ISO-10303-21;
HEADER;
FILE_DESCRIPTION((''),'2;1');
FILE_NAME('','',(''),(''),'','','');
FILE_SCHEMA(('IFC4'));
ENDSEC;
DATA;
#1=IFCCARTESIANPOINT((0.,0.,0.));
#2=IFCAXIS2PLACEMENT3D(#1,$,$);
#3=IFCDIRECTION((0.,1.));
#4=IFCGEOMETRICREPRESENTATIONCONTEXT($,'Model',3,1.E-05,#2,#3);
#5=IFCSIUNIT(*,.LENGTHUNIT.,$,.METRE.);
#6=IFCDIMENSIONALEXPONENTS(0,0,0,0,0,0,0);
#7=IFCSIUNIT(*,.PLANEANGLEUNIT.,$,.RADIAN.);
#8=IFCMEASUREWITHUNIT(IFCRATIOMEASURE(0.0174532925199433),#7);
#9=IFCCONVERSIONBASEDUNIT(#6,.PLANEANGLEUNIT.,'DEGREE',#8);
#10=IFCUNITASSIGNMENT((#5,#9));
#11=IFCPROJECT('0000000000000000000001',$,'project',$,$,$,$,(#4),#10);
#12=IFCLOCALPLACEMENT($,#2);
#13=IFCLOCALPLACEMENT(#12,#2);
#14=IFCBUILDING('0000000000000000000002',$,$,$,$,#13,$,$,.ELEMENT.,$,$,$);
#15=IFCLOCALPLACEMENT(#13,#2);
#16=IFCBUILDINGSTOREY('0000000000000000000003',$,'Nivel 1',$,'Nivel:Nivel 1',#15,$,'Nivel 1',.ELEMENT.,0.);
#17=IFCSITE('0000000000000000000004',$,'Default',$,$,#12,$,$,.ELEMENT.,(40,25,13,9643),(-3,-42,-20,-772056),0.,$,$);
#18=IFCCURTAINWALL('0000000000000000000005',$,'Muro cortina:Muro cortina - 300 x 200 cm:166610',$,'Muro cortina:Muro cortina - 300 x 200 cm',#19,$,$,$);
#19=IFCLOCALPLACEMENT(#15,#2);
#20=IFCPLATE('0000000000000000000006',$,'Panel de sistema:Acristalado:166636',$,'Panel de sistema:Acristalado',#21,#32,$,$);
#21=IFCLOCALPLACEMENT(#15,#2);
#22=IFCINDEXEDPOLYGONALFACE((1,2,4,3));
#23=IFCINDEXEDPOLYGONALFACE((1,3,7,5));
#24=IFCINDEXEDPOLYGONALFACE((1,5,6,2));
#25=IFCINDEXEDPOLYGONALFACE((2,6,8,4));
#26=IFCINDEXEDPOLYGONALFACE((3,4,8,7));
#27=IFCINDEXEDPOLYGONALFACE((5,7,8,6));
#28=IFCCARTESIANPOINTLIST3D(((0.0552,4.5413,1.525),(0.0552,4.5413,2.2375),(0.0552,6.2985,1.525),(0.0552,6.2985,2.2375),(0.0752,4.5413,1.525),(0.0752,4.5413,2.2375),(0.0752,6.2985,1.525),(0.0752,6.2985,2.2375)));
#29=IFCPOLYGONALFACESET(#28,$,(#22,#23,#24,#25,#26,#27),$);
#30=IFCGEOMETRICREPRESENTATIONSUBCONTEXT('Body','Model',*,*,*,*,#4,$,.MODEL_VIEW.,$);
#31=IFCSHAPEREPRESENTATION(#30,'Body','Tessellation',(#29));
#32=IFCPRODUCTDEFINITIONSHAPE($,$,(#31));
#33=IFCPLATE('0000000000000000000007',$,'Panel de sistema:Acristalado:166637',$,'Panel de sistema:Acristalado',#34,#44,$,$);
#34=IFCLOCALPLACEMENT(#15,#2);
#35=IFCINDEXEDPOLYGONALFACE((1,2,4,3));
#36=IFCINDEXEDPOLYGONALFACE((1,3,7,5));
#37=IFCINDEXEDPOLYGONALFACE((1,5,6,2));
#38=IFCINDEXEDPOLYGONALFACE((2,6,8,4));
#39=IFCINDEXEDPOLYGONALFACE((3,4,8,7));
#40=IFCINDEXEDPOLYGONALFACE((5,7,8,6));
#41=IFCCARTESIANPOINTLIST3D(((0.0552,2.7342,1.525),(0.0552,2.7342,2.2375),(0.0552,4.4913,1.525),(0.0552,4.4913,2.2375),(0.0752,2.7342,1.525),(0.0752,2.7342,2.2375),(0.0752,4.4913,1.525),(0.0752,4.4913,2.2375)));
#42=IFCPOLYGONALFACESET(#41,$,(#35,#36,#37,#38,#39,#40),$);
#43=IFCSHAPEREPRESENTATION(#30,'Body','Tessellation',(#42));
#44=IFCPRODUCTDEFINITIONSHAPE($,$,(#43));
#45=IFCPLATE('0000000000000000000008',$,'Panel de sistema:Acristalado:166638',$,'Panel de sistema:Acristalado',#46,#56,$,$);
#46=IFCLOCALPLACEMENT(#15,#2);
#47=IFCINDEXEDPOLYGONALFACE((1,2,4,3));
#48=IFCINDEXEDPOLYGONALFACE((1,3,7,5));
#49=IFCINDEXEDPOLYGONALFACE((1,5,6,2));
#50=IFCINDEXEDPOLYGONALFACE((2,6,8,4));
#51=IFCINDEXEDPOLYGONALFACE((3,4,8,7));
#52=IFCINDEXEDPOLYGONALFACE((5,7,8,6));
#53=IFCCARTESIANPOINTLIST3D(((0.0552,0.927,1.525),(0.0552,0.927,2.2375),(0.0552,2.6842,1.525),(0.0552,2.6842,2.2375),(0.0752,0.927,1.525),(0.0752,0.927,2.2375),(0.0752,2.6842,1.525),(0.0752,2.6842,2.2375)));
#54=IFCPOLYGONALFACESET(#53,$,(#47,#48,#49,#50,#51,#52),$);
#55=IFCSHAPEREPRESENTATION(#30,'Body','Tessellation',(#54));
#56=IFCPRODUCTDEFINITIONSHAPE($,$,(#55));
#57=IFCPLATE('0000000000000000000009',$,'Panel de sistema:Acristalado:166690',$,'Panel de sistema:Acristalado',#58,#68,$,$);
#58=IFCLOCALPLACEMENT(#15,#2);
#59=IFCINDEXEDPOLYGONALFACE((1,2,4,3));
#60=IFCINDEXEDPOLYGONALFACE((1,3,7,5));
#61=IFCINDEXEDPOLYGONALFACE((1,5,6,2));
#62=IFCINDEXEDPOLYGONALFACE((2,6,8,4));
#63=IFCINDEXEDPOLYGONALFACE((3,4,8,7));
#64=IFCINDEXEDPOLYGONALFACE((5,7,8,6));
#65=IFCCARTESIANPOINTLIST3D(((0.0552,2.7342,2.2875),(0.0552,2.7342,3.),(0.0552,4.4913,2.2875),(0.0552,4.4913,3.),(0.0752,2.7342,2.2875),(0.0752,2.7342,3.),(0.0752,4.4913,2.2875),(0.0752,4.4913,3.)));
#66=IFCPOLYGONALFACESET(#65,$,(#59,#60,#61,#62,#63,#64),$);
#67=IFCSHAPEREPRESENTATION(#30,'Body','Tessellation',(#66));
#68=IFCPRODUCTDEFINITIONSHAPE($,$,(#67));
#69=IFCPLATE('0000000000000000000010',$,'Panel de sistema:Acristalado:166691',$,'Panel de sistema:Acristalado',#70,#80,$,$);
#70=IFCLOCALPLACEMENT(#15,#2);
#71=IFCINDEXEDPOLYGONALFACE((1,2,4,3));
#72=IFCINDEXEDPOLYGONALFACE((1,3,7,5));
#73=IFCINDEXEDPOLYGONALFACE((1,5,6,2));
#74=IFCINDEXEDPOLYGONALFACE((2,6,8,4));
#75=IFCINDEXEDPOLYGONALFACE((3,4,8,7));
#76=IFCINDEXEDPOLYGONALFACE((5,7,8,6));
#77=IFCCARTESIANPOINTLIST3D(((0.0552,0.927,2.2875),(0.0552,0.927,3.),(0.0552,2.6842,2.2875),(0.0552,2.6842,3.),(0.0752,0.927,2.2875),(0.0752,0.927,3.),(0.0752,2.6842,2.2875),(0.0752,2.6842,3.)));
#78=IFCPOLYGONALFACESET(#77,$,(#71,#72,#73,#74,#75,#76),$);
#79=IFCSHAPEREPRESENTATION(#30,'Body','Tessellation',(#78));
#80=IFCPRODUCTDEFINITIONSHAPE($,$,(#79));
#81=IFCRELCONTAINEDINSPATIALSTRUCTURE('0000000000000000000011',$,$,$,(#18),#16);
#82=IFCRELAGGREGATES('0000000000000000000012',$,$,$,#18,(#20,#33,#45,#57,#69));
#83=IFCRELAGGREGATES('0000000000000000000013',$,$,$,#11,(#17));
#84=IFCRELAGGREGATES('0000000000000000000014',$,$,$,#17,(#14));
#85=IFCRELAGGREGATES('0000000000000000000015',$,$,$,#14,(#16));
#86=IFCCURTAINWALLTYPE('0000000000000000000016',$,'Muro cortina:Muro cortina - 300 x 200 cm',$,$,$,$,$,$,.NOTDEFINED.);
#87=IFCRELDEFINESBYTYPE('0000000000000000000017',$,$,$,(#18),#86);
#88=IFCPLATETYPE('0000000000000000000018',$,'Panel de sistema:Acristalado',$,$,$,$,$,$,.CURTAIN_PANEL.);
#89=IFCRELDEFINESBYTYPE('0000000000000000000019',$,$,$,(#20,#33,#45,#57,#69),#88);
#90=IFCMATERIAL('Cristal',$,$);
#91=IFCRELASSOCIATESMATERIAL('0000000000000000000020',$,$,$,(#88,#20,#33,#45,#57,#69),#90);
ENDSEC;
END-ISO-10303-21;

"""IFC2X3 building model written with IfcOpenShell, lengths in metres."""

from ifc_helpers import new_model, entity, si_unit, converted_unit, direction, frame, origin, origin_2d_with_axis, place, context, subcontext, project, spatial, rectangle, extrude, source, transform, mapped, material, type_object, type_shapes, element, aggregate, save


model = new_model("IFC2X3")

# Units and contexts
model_context = context("Model", 3, precision=1e-05, world=origin(), true_north=direction((0.0, 1.0)))
body_context = subcontext(model_context, "Body", "Model", "MODEL_VIEW")
ifc_project = project(units=[si_unit("LENGTHUNIT", "METRE"), converted_unit("PLANEANGLEUNIT", "DEGREE", entity("IfcRatioMeasure", 0.0174532925199433), si_unit("PLANEANGLEUNIT", "RADIAN"), dimensions=[0, 0, 0, 0, 0, 0, 0])], contexts=[model_context])

# Site, building, storey
site_placement = place(None, origin())
site = spatial("IfcSite", under=ifc_project, at=site_placement, Name="Default", CompositionType="ELEMENT", RefLatitude=(40, 25, 13, 9643), RefLongitude=(-3, -42, -20, -772056), RefElevation=0.0)
building_placement = place(site_placement, origin())
building = spatial("IfcBuilding", under=site, at=building_placement, CompositionType="ELEMENT")
storey_placement = place(building_placement, origin())
storey = spatial("IfcBuildingStorey", under=building, at=storey_placement, Name="Nivel 1", ObjectType="Nivel:Nivel 1", LongName="Nivel 1", CompositionType="ELEMENT", Elevation=0.0)

# Curtain wall, plates
curtain_wall_type = type_object("IfcCurtainWallType", Name="Muro cortina:Muro cortina - 300 x 200 cm", PredefinedType="NOTDEFINED")
curtain_wall_placement = place(storey_placement, origin())
curtain_wall = element("IfcCurtainWall", 1, at=curtain_wall_placement, inside=storey, type_object=curtain_wall_type, Name="Muro cortina:Muro cortina - 300 x 200 cm:166610", ObjectType="Muro cortina:Muro cortina - 300 x 200 cm")
ifc_material_1 = material(Name="Cristal")
plate_type = type_object("IfcPlateType", Name="Panel de sistema:Acristalado", PredefinedType="CURTAIN_PANEL", material=ifc_material_1)
shared_shape_1 = source(origin(), body_context, "Body", "SweptSolid", [
    extrude(rectangle(XDim=0.02, YDim=1.7571, at=origin_2d_with_axis()), frame((0.0, 0.0, 0.0), z_axis=(0.0, 0.0, 1.0), x_axis=(0.0, 1.0, 0.0)), (0.0, 0.0, 1.0), 0.7125),
])
type_shapes(plate_type, [shared_shape_1])
plate_1_placement = place(curtain_wall_placement, frame((0.0652, 5.4199, 1.525), z_axis=(0.0, 0.0, 1.0), x_axis=(0.0, -1.0, 0.0)))
plate_1 = element("IfcPlate", 2, at=plate_1_placement, type_object=plate_type, material=ifc_material_1, Name="Panel de sistema:Acristalado:166636", ObjectType="Panel de sistema:Acristalado", context=body_context, shape_type="MappedRepresentation", body=[
    mapped(shared_shape_1, transform((0.0, 0.0, 0.0), scale=1.0)),
])
plate_2_placement = place(curtain_wall_placement, frame((0.0652, 3.6127, 1.525), z_axis=(0.0, 0.0, 1.0), x_axis=(0.0, -1.0, 0.0)))
plate_2 = element("IfcPlate", 3, at=plate_2_placement, type_object=plate_type, material=ifc_material_1, Name="Panel de sistema:Acristalado:166637", ObjectType="Panel de sistema:Acristalado", context=body_context, shape_type="MappedRepresentation", body=[
    mapped(shared_shape_1, transform((0.0, 0.0, 0.0), scale=1.0)),
])
plate_3_placement = place(curtain_wall_placement, frame((0.0652, 1.8056, 1.525), z_axis=(0.0, 0.0, 1.0), x_axis=(0.0, -1.0, 0.0)))
plate_3 = element("IfcPlate", 4, at=plate_3_placement, type_object=plate_type, material=ifc_material_1, Name="Panel de sistema:Acristalado:166638", ObjectType="Panel de sistema:Acristalado", context=body_context, shape_type="MappedRepresentation", body=[
    mapped(shared_shape_1, transform((0.0, 0.0, 0.0), scale=1.0)),
])
plate_4_placement = place(curtain_wall_placement, frame((0.0652, 3.6127, 2.2875), z_axis=(0.0, 0.0, 1.0), x_axis=(0.0, -1.0, 0.0)))
plate_4 = element("IfcPlate", 5, at=plate_4_placement, type_object=plate_type, material=ifc_material_1, Name="Panel de sistema:Acristalado:166690", ObjectType="Panel de sistema:Acristalado", context=body_context, shape_type="MappedRepresentation", body=[
    mapped(shared_shape_1, transform((0.0, 0.0, 0.0), scale=1.0)),
])
plate_5_placement = place(curtain_wall_placement, frame((0.0652, 1.8056, 2.2875), z_axis=(0.0, 0.0, 1.0), x_axis=(0.0, -1.0, 0.0)))
plate_5 = element("IfcPlate", 6, at=plate_5_placement, type_object=plate_type, material=ifc_material_1, Name="Panel de sistema:Acristalado:166691", ObjectType="Panel de sistema:Acristalado", context=body_context, shape_type="MappedRepresentation", body=[
    mapped(shared_shape_1, transform((0.0, 0.0, 0.0), scale=1.0)),
])
aggregate(curtain_wall, [plate_1, plate_2, plate_3, plate_4, plate_5])

save(model, "model.ifc")
